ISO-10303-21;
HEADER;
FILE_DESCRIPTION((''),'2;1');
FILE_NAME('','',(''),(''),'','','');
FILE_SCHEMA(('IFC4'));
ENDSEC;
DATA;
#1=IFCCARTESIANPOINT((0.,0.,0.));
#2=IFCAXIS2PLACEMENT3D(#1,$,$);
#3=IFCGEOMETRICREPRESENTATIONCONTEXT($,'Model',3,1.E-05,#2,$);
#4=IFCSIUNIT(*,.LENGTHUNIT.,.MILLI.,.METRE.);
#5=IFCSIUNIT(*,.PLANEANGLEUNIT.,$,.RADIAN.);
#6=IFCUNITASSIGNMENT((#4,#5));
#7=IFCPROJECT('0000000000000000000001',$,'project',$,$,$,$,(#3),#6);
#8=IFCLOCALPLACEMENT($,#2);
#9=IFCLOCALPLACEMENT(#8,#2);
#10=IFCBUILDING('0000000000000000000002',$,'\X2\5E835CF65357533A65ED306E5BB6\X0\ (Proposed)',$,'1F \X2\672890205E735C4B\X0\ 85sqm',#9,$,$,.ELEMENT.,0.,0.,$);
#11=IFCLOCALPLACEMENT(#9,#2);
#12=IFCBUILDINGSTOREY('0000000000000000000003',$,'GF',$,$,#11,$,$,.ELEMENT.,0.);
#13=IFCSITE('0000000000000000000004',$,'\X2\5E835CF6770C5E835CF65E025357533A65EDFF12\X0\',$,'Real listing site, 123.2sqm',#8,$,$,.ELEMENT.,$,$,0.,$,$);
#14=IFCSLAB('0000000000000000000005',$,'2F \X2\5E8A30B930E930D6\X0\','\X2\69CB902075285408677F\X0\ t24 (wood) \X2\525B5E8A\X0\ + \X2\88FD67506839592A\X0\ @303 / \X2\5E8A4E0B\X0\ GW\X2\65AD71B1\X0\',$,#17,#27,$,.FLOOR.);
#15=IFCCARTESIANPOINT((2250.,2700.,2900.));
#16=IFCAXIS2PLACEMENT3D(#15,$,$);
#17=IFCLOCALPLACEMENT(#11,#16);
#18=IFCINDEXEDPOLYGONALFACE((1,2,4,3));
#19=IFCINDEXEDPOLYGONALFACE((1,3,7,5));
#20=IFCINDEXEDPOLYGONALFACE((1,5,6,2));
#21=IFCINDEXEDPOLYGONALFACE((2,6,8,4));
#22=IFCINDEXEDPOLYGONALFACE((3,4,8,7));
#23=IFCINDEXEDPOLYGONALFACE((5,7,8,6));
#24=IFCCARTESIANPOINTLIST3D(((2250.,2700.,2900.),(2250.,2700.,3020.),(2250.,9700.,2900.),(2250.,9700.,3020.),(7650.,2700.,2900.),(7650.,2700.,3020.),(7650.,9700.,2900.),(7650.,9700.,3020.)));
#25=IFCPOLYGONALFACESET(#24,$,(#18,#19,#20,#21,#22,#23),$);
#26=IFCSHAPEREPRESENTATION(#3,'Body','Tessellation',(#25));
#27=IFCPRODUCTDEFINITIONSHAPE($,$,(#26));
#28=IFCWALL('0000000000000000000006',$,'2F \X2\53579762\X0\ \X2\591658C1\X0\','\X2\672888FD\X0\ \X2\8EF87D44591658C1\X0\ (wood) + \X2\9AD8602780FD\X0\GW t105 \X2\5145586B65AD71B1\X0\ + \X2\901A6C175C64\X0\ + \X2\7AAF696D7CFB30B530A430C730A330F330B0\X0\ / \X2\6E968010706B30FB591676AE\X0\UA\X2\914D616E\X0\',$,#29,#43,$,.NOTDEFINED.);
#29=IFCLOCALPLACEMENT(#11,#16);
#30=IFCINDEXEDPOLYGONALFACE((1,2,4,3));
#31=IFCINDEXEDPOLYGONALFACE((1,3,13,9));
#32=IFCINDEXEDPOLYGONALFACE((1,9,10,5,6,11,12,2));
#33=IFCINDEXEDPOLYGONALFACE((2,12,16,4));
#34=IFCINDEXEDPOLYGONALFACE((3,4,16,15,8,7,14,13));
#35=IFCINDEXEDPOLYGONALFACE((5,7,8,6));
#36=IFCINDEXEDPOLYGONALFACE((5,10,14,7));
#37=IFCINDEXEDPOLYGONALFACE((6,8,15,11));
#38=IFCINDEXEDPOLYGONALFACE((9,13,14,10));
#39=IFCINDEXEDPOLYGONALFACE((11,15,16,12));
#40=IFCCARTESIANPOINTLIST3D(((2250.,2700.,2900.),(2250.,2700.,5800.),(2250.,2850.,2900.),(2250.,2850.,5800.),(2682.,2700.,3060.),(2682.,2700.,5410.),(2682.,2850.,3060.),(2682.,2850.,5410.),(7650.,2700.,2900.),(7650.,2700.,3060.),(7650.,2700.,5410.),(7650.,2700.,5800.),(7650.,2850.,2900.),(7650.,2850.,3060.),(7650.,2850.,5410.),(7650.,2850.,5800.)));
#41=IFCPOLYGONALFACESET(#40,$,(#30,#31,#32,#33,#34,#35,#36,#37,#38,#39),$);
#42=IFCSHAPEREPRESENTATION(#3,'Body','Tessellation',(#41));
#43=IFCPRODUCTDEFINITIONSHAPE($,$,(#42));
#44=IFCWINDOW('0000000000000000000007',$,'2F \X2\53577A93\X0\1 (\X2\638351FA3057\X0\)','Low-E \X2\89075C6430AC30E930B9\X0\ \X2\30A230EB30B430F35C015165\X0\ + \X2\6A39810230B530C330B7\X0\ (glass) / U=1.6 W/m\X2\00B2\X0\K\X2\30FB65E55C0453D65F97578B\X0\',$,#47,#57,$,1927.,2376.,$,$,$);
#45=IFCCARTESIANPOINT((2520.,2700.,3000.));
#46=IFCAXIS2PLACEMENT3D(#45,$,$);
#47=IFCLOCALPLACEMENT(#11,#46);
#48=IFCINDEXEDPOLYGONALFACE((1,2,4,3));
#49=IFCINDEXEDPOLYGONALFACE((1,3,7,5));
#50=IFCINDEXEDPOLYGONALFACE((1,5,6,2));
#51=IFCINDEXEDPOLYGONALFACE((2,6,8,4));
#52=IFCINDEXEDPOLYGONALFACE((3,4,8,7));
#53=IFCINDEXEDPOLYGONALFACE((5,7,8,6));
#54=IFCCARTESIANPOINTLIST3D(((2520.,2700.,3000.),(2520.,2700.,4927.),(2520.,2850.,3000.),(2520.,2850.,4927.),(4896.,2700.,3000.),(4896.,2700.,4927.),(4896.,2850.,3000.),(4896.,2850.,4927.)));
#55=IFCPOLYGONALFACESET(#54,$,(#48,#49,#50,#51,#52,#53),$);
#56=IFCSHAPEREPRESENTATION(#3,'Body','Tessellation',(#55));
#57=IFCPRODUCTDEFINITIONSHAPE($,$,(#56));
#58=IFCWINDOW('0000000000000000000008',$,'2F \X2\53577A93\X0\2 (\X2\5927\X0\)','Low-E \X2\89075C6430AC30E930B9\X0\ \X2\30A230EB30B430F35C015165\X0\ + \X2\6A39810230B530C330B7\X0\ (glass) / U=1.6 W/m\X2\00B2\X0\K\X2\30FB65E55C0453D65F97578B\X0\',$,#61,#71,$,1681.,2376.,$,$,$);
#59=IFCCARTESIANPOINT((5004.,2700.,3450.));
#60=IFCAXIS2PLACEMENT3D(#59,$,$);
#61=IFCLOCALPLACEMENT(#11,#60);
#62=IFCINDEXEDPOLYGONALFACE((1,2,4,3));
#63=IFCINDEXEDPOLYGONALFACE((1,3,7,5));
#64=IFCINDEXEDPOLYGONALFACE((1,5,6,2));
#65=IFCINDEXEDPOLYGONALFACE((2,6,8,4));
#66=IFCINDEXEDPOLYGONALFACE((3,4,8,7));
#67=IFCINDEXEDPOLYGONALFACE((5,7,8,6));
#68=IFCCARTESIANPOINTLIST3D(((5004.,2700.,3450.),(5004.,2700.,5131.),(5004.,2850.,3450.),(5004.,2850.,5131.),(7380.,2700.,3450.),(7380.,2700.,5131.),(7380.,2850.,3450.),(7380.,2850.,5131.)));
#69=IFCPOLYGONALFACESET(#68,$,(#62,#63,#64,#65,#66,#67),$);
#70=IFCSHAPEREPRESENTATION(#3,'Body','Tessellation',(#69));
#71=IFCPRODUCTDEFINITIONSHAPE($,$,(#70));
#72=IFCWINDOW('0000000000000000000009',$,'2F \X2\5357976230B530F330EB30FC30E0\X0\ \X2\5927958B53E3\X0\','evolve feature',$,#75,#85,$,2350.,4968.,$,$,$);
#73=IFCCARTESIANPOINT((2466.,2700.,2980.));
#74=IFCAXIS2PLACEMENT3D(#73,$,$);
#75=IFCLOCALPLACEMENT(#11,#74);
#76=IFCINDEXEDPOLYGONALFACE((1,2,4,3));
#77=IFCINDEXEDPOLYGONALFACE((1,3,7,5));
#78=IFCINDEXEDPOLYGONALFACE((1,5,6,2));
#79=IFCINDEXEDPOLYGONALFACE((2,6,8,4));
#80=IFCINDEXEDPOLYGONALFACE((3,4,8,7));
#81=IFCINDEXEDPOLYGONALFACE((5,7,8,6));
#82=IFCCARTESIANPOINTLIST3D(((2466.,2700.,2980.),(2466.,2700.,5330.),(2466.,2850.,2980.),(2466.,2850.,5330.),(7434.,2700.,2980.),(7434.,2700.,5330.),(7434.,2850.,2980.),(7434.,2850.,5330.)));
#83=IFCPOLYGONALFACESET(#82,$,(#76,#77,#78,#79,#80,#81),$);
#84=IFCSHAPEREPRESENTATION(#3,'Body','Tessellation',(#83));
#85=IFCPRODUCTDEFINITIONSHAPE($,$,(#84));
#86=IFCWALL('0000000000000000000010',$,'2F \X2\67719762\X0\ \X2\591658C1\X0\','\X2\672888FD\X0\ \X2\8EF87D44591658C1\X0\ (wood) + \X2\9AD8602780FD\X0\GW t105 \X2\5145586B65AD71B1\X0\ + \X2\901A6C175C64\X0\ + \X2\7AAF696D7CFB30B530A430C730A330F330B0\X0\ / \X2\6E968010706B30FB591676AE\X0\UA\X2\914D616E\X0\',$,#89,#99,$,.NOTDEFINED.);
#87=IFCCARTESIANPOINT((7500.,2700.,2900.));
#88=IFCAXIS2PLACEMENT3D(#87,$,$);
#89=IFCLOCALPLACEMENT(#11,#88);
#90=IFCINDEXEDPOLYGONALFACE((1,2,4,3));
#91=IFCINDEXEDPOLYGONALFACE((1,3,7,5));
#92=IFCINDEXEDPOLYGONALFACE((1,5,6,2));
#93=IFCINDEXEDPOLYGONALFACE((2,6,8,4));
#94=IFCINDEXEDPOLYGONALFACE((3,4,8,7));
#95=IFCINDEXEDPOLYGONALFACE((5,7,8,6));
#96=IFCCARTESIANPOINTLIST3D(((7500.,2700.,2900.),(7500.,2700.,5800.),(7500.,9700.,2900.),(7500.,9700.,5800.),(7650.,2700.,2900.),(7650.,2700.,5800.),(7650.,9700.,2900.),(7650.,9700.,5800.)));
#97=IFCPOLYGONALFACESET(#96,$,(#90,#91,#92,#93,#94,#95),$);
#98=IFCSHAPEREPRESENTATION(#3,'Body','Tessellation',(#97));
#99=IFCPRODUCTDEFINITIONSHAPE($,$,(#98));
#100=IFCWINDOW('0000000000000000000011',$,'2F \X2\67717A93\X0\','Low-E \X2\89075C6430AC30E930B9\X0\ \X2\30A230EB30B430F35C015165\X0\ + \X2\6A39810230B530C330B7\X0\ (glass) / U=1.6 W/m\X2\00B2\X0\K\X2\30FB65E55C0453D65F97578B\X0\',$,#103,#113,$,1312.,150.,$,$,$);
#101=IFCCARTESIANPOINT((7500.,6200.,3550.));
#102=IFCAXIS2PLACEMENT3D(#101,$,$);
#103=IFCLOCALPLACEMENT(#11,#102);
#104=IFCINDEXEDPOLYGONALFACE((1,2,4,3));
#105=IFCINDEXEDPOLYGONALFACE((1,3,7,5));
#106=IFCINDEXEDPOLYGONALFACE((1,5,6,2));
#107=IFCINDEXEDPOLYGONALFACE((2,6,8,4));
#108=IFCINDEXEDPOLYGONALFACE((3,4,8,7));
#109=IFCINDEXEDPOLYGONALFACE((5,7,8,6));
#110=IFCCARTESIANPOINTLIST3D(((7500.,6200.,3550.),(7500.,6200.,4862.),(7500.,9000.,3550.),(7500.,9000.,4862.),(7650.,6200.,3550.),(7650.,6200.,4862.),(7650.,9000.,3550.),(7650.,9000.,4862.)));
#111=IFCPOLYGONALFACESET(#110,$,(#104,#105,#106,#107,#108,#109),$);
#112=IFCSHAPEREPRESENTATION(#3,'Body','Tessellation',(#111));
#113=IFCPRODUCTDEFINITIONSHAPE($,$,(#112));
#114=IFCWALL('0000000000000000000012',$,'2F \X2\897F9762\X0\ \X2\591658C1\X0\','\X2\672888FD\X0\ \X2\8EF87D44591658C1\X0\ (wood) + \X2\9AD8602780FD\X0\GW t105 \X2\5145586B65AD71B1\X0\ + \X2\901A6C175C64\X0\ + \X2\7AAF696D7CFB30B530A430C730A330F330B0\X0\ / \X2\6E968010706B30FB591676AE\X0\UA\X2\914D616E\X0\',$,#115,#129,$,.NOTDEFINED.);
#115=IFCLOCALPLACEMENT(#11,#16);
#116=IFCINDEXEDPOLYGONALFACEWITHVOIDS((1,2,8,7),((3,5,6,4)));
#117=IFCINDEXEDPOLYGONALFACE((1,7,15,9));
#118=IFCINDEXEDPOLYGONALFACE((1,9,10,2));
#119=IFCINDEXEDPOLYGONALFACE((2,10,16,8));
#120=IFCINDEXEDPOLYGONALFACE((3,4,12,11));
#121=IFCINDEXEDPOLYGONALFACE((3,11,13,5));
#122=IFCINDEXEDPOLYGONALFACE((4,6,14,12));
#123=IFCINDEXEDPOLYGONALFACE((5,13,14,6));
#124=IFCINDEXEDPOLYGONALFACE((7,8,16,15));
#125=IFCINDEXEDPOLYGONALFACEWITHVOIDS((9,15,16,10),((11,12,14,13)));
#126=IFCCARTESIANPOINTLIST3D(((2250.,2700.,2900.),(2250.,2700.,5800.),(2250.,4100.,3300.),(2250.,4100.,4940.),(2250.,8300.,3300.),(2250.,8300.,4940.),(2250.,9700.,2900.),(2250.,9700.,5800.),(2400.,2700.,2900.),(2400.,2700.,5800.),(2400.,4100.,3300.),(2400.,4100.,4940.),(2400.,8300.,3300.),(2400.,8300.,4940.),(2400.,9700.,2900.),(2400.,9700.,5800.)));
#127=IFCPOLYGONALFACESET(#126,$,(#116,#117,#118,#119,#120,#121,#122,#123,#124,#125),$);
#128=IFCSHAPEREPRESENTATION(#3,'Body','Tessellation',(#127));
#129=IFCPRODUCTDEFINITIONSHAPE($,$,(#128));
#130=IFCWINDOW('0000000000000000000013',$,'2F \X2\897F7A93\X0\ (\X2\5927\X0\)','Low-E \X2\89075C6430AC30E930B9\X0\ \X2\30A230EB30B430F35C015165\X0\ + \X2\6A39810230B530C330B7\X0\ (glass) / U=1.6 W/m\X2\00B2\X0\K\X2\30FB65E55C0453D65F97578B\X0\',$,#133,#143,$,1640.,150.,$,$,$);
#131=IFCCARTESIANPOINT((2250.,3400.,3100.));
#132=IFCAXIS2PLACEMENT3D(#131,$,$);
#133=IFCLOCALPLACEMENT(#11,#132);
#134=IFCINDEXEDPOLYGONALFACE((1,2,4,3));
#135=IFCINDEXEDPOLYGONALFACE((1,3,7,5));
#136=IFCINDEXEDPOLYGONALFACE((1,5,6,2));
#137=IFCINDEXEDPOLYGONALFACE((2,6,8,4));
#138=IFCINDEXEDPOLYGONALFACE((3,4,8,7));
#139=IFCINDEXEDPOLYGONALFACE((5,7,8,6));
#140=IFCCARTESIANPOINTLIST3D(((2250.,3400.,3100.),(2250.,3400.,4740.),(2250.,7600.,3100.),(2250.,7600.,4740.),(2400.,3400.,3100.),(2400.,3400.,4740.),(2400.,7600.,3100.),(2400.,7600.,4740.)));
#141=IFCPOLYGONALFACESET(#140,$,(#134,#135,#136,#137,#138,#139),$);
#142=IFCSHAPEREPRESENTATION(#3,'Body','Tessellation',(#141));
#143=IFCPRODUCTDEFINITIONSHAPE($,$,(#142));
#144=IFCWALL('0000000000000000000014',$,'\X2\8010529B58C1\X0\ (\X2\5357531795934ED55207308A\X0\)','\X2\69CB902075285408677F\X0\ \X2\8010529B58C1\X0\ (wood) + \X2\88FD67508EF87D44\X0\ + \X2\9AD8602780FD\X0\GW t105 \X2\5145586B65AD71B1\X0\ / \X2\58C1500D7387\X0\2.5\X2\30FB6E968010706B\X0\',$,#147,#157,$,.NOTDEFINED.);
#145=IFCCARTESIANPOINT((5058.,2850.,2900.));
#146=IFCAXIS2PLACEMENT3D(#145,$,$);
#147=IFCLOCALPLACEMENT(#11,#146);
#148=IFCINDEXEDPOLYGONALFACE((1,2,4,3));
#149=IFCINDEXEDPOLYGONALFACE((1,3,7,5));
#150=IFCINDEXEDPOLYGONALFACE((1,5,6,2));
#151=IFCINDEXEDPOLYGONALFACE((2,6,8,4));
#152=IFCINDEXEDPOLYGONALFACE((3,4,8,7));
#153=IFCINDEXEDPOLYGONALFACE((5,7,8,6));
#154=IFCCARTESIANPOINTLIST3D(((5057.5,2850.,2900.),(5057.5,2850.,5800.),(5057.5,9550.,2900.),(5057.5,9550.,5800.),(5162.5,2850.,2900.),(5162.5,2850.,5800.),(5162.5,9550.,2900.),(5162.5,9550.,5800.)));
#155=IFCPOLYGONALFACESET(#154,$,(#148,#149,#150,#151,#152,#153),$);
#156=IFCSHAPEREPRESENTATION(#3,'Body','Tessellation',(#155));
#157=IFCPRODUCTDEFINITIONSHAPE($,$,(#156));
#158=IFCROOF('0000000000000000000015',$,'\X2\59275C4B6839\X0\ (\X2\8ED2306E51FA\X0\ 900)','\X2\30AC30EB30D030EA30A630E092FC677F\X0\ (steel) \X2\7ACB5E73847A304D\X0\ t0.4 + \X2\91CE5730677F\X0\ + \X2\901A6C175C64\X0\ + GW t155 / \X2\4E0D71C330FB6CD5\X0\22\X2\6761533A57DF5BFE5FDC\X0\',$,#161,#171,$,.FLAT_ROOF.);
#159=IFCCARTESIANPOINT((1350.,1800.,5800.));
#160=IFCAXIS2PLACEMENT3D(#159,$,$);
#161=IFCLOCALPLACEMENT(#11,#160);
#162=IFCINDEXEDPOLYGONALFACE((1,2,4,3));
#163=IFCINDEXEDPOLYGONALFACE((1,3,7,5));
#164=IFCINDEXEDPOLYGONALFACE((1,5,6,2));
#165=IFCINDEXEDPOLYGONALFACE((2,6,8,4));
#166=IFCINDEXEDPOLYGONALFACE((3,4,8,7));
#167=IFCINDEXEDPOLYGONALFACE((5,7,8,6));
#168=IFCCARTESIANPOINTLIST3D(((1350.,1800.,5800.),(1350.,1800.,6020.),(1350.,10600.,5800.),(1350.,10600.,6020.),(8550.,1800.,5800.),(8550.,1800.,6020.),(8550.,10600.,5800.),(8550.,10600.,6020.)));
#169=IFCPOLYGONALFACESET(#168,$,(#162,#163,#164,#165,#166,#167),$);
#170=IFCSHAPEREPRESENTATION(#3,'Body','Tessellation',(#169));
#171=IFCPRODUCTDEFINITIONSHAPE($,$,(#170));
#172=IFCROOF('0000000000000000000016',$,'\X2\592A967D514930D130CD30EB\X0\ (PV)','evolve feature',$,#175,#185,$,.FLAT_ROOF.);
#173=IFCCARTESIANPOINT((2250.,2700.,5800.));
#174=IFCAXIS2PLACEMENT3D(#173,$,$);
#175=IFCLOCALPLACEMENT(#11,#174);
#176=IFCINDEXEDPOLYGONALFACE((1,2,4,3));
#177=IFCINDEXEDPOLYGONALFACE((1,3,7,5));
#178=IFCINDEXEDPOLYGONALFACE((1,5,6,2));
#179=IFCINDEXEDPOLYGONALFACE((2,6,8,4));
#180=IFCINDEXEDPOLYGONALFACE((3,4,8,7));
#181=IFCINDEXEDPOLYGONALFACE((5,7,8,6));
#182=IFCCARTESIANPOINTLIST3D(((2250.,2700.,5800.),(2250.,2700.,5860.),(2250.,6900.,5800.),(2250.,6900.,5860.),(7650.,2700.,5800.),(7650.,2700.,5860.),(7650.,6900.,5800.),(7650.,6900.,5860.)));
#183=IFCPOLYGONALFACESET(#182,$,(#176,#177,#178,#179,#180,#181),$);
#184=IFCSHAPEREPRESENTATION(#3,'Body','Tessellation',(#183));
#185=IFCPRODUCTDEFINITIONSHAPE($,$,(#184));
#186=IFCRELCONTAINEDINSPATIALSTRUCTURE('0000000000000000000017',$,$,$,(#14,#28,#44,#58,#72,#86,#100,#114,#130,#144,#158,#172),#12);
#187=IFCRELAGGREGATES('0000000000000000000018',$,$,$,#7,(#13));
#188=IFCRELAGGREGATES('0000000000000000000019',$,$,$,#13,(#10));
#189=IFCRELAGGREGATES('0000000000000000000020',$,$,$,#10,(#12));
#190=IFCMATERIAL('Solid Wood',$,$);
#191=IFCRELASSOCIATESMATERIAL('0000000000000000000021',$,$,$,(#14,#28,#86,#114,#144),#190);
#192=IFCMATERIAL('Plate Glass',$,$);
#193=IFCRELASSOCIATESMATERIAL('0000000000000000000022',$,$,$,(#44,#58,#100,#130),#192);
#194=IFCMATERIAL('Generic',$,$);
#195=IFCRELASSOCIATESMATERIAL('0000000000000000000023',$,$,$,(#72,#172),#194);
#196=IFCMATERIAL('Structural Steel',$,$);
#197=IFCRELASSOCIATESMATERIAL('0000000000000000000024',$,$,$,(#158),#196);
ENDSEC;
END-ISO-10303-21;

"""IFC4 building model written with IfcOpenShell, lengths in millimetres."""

from ifc_helpers import new_model, si_unit, frame, frame_2d, origin, place, context, project, spatial, rectangle, extrude, material, element, fill, save


model = new_model("IFC4")

# Units and contexts
model_context = context("Model", 3, precision=1e-05, world=origin())
ifc_project = project(units=[si_unit("LENGTHUNIT", "METRE", prefix="MILLI"), si_unit("PLANEANGLEUNIT", "RADIAN")], contexts=[model_context])

# Site, building, storey
site_placement = place(None, origin())
site = spatial("IfcSite", under=ifc_project, at=site_placement, Name="広島県広島市南区旭２", ObjectType="Real listing site, 123.2sqm", CompositionType="ELEMENT", RefElevation=0.0)
building_placement = place(site_placement, origin())
building = spatial("IfcBuilding", under=site, at=building_placement, Name="広島南区旭の家 (Proposed)", ObjectType="1F 木造平屋 85sqm", CompositionType="ELEMENT", ElevationOfRefHeight=0.0, ElevationOfTerrain=0.0)
storey_placement = place(building_placement, origin())
storey = spatial("IfcBuildingStorey", under=building, at=storey_placement, Name="GF", CompositionType="ELEMENT", Elevation=0.0)

# Slab
ifc_material_1 = material(Name="Solid Wood")
slab_placement = place(storey_placement, frame((2250.0, 2700.0, 2900.0)))
element("IfcSlab", 1, at=slab_placement, inside=storey, material=ifc_material_1, Name="2F 床スラブ", Description="構造用合板 t24 (wood) 剛床 + 製材根太 @303 / 床下 GW断熱", PredefinedType="FLOOR", context=model_context, shape_type="SweptSolid", body=[
    extrude(rectangle(XDim=5400.0, YDim=7000.0, at=frame_2d((2700.0, 3500.0))), frame((2250.0, 2700.0, 2900.0)), (0.0, 0.0, 1.0), 120.0),
])

# Wall, openings, windows
wall_1_placement = place(storey_placement, frame((2250.0, 2700.0, 2900.0)))
wall_1 = element("IfcWall", 2, at=wall_1_placement, inside=storey, material=ifc_material_1, Name="2F 南面 外壁", Description="木製 軸組外壁 (wood) + 高性能GW t105 充填断熱 + 通気層 + 窯業系サイディング / 準耐火・外皮UA配慮", PredefinedType="NOTDEFINED", context=model_context, shape_type="SweptSolid", body=[
    extrude(rectangle(XDim=5400.0, YDim=150.0, at=frame_2d((2700.0, 75.0))), frame((2250.0, 2700.0, 2900.0)), (0.0, 0.0, 1.0), 2900.0),
])
opening_1_placement = place(storey_placement, frame((2520.0, 2700.0, 3000.0)))
opening_1 = element("IfcOpeningElement", 3, at=opening_1_placement, cuts=wall_1, PredefinedType="NOTDEFINED", context=model_context, shape_type="SweptSolid", body=[
    extrude(rectangle(XDim=2376.0, YDim=150.0, at=frame_2d((1188.0, 75.0))), frame((2520.0, 2700.0, 3000.0)), (0.0, 0.0, 1.0), 1927.0),
])
opening_2_placement = place(storey_placement, frame((5004.0, 2700.0, 3450.0)))
opening_2 = element("IfcOpeningElement", 4, at=opening_2_placement, cuts=wall_1, PredefinedType="NOTDEFINED", context=model_context, shape_type="SweptSolid", body=[
    extrude(rectangle(XDim=2376.0, YDim=150.0, at=frame_2d((1188.0, 75.0))), frame((5004.0, 2700.0, 3450.0)), (0.0, 0.0, 1.0), 1681.0),
])
opening_3_placement = place(storey_placement, frame((2466.0, 2700.0, 2980.0)))
opening_3 = element("IfcOpeningElement", 5, at=opening_3_placement, cuts=wall_1, PredefinedType="NOTDEFINED", context=model_context, shape_type="SweptSolid", body=[
    extrude(rectangle(XDim=4968.0, YDim=150.0, at=frame_2d((2484.0, 75.0))), frame((2466.0, 2700.0, 2980.0)), (0.0, 0.0, 1.0), 2350.0),
])
ifc_material_2 = material(Name="Plate Glass")
window_1_placement = place(storey_placement, frame((2520.0, 2700.0, 3000.0)))
window_1 = element("IfcWindow", 6, at=window_1_placement, inside=storey, material=ifc_material_2, Name="2F 南窓1 (掃出し)", Description="Low-E 複層ガラス アルゴン封入 + 樹脂サッシ (glass) / U=1.6 W/m²K・日射取得型", OverallHeight=1927.0, OverallWidth=2376.0, context=model_context, shape_type="SweptSolid", body=[
    extrude(rectangle(XDim=2376.0, YDim=150.0, at=frame_2d((1188.0, 75.0))), frame((2520.0, 2700.0, 3000.0)), (0.0, 0.0, 1.0), 1927.0),
])
fill(opening_1, window_1)
window_2_placement = place(storey_placement, frame((5004.0, 2700.0, 3450.0)))
window_2 = element("IfcWindow", 7, at=window_2_placement, inside=storey, material=ifc_material_2, Name="2F 南窓2 (大)", Description="Low-E 複層ガラス アルゴン封入 + 樹脂サッシ (glass) / U=1.6 W/m²K・日射取得型", OverallHeight=1681.0, OverallWidth=2376.0, context=model_context, shape_type="SweptSolid", body=[
    extrude(rectangle(XDim=2376.0, YDim=150.0, at=frame_2d((1188.0, 75.0))), frame((5004.0, 2700.0, 3450.0)), (0.0, 0.0, 1.0), 1681.0),
])
fill(opening_2, window_2)
ifc_material_3 = material(Name="Generic")
window_3_placement = place(storey_placement, frame((2466.0, 2700.0, 2980.0)))
window_3 = element("IfcWindow", 8, at=window_3_placement, inside=storey, material=ifc_material_3, Name="2F 南面サンルーム 大開口", Description="evolve feature", OverallHeight=2350.0, OverallWidth=4968.0, context=model_context, shape_type="SweptSolid", body=[
    extrude(rectangle(XDim=4968.0, YDim=150.0, at=frame_2d((2484.0, 75.0))), frame((2466.0, 2700.0, 2980.0)), (0.0, 0.0, 1.0), 2350.0),
])
fill(opening_3, window_3)

# Walls, openings, windows
wall_2_placement = place(storey_placement, frame((7500.0, 2700.0, 2900.0)))
wall_2 = element("IfcWall", 9, at=wall_2_placement, inside=storey, material=ifc_material_1, Name="2F 東面 外壁", Description="木製 軸組外壁 (wood) + 高性能GW t105 充填断熱 + 通気層 + 窯業系サイディング / 準耐火・外皮UA配慮", PredefinedType="NOTDEFINED", context=model_context, shape_type="SweptSolid", body=[
    extrude(rectangle(XDim=150.0, YDim=7000.0, at=frame_2d((75.0, 3500.0))), frame((7500.0, 2700.0, 2900.0)), (0.0, 0.0, 1.0), 2900.0),
])
opening_4_placement = place(storey_placement, frame((7500.0, 6200.0, 3550.0)))
opening_4 = element("IfcOpeningElement", 10, at=opening_4_placement, cuts=wall_2, PredefinedType="NOTDEFINED", context=model_context, shape_type="SweptSolid", body=[
    extrude(rectangle(XDim=150.0, YDim=2800.0, at=frame_2d((75.0, 1400.0))), frame((7500.0, 6200.0, 3550.0)), (0.0, 0.0, 1.0), 1312.0),
])
window_4_placement = place(storey_placement, frame((7500.0, 6200.0, 3550.0)))
window_4 = element("IfcWindow", 11, at=window_4_placement, inside=storey, material=ifc_material_2, Name="2F 東窓", Description="Low-E 複層ガラス アルゴン封入 + 樹脂サッシ (glass) / U=1.6 W/m²K・日射取得型", OverallHeight=1312.0, OverallWidth=150.0, context=model_context, shape_type="SweptSolid", body=[
    extrude(rectangle(XDim=150.0, YDim=2800.0, at=frame_2d((75.0, 1400.0))), frame((7500.0, 6200.0, 3550.0)), (0.0, 0.0, 1.0), 1312.0),
])
fill(opening_4, window_4)
wall_3_placement = place(storey_placement, frame((2250.0, 2700.0, 2900.0)))
wall_3 = element("IfcWall", 12, at=wall_3_placement, inside=storey, material=ifc_material_1, Name="2F 西面 外壁", Description="木製 軸組外壁 (wood) + 高性能GW t105 充填断熱 + 通気層 + 窯業系サイディング / 準耐火・外皮UA配慮", PredefinedType="NOTDEFINED", context=model_context, shape_type="SweptSolid", body=[
    extrude(rectangle(XDim=150.0, YDim=7000.0, at=frame_2d((75.0, 3500.0))), frame((2250.0, 2700.0, 2900.0)), (0.0, 0.0, 1.0), 2900.0),
])
opening_5_placement = place(storey_placement, frame((2250.0, 3400.0, 3100.0)))
opening_5 = element("IfcOpeningElement", 13, at=opening_5_placement, cuts=wall_3, PredefinedType="NOTDEFINED", context=model_context, shape_type="SweptSolid", body=[
    extrude(rectangle(XDim=150.0, YDim=4200.0, at=frame_2d((75.0, 2100.0))), frame((2250.0, 3400.0, 3100.0)), (0.0, 0.0, 1.0), 1640.0),
])
window_5_placement = place(storey_placement, frame((2250.0, 3400.0, 3100.0)))
window_5 = element("IfcWindow", 14, at=window_5_placement, inside=storey, material=ifc_material_2, Name="2F 西窓 (大)", Description="Low-E 複層ガラス アルゴン封入 + 樹脂サッシ (glass) / U=1.6 W/m²K・日射取得型", OverallHeight=1640.0, OverallWidth=150.0, context=model_context, shape_type="SweptSolid", body=[
    extrude(rectangle(XDim=150.0, YDim=4200.0, at=frame_2d((75.0, 2100.0))), frame((2250.0, 3400.0, 3100.0)), (0.0, 0.0, 1.0), 1640.0),
])
fill(opening_5, window_5)

# Wall
wall_4_placement = place(storey_placement, frame((5058.0, 2850.0, 2900.0)))
element("IfcWall", 15, at=wall_4_placement, inside=storey, material=ifc_material_1, Name="耐力壁 (南北間仕切り)", Description="構造用合板 耐力壁 (wood) + 製材軸組 + 高性能GW t105 充填断熱 / 壁倍率2.5・準耐火", PredefinedType="NOTDEFINED", context=model_context, shape_type="SweptSolid", body=[
    extrude(rectangle(XDim=105.0, YDim=6700.0, at=frame_2d((52.0, 3350.0))), frame((5058.0, 2850.0, 2900.0)), (0.0, 0.0, 1.0), 2900.0),
])

# Roofs
ifc_material_4 = material(Name="Structural Steel")
roof_1_placement = place(storey_placement, frame((1350.0, 1800.0, 5800.0)))
element("IfcRoof", 16, at=roof_1_placement, inside=storey, material=ifc_material_4, Name="大屋根 (軒の出 900)", Description="ガルバリウム鋼板 (steel) 立平葺き t0.4 + 野地板 + 通気層 + GW t155 / 不燃・法22条区域対応", PredefinedType="FLAT_ROOF", context=model_context, shape_type="SweptSolid", body=[
    extrude(rectangle(XDim=7200.0, YDim=8800.0, at=frame_2d((3600.0, 4400.0))), frame((1350.0, 1800.0, 5800.0)), (0.0, 0.0, 1.0), 220.0),
])
roof_2_placement = place(storey_placement, frame((2250.0, 2700.0, 5800.0)))
element("IfcRoof", 17, at=roof_2_placement, inside=storey, material=ifc_material_3, Name="太陽光パネル (PV)", Description="evolve feature", PredefinedType="FLAT_ROOF", context=model_context, shape_type="SweptSolid", body=[
    extrude(rectangle(XDim=5400.0, YDim=4200.0, at=frame_2d((2700.0, 2100.0))), frame((2250.0, 2700.0, 5800.0)), (0.0, 0.0, 1.0), 60.0),
])

save(model, "model.ifc")
